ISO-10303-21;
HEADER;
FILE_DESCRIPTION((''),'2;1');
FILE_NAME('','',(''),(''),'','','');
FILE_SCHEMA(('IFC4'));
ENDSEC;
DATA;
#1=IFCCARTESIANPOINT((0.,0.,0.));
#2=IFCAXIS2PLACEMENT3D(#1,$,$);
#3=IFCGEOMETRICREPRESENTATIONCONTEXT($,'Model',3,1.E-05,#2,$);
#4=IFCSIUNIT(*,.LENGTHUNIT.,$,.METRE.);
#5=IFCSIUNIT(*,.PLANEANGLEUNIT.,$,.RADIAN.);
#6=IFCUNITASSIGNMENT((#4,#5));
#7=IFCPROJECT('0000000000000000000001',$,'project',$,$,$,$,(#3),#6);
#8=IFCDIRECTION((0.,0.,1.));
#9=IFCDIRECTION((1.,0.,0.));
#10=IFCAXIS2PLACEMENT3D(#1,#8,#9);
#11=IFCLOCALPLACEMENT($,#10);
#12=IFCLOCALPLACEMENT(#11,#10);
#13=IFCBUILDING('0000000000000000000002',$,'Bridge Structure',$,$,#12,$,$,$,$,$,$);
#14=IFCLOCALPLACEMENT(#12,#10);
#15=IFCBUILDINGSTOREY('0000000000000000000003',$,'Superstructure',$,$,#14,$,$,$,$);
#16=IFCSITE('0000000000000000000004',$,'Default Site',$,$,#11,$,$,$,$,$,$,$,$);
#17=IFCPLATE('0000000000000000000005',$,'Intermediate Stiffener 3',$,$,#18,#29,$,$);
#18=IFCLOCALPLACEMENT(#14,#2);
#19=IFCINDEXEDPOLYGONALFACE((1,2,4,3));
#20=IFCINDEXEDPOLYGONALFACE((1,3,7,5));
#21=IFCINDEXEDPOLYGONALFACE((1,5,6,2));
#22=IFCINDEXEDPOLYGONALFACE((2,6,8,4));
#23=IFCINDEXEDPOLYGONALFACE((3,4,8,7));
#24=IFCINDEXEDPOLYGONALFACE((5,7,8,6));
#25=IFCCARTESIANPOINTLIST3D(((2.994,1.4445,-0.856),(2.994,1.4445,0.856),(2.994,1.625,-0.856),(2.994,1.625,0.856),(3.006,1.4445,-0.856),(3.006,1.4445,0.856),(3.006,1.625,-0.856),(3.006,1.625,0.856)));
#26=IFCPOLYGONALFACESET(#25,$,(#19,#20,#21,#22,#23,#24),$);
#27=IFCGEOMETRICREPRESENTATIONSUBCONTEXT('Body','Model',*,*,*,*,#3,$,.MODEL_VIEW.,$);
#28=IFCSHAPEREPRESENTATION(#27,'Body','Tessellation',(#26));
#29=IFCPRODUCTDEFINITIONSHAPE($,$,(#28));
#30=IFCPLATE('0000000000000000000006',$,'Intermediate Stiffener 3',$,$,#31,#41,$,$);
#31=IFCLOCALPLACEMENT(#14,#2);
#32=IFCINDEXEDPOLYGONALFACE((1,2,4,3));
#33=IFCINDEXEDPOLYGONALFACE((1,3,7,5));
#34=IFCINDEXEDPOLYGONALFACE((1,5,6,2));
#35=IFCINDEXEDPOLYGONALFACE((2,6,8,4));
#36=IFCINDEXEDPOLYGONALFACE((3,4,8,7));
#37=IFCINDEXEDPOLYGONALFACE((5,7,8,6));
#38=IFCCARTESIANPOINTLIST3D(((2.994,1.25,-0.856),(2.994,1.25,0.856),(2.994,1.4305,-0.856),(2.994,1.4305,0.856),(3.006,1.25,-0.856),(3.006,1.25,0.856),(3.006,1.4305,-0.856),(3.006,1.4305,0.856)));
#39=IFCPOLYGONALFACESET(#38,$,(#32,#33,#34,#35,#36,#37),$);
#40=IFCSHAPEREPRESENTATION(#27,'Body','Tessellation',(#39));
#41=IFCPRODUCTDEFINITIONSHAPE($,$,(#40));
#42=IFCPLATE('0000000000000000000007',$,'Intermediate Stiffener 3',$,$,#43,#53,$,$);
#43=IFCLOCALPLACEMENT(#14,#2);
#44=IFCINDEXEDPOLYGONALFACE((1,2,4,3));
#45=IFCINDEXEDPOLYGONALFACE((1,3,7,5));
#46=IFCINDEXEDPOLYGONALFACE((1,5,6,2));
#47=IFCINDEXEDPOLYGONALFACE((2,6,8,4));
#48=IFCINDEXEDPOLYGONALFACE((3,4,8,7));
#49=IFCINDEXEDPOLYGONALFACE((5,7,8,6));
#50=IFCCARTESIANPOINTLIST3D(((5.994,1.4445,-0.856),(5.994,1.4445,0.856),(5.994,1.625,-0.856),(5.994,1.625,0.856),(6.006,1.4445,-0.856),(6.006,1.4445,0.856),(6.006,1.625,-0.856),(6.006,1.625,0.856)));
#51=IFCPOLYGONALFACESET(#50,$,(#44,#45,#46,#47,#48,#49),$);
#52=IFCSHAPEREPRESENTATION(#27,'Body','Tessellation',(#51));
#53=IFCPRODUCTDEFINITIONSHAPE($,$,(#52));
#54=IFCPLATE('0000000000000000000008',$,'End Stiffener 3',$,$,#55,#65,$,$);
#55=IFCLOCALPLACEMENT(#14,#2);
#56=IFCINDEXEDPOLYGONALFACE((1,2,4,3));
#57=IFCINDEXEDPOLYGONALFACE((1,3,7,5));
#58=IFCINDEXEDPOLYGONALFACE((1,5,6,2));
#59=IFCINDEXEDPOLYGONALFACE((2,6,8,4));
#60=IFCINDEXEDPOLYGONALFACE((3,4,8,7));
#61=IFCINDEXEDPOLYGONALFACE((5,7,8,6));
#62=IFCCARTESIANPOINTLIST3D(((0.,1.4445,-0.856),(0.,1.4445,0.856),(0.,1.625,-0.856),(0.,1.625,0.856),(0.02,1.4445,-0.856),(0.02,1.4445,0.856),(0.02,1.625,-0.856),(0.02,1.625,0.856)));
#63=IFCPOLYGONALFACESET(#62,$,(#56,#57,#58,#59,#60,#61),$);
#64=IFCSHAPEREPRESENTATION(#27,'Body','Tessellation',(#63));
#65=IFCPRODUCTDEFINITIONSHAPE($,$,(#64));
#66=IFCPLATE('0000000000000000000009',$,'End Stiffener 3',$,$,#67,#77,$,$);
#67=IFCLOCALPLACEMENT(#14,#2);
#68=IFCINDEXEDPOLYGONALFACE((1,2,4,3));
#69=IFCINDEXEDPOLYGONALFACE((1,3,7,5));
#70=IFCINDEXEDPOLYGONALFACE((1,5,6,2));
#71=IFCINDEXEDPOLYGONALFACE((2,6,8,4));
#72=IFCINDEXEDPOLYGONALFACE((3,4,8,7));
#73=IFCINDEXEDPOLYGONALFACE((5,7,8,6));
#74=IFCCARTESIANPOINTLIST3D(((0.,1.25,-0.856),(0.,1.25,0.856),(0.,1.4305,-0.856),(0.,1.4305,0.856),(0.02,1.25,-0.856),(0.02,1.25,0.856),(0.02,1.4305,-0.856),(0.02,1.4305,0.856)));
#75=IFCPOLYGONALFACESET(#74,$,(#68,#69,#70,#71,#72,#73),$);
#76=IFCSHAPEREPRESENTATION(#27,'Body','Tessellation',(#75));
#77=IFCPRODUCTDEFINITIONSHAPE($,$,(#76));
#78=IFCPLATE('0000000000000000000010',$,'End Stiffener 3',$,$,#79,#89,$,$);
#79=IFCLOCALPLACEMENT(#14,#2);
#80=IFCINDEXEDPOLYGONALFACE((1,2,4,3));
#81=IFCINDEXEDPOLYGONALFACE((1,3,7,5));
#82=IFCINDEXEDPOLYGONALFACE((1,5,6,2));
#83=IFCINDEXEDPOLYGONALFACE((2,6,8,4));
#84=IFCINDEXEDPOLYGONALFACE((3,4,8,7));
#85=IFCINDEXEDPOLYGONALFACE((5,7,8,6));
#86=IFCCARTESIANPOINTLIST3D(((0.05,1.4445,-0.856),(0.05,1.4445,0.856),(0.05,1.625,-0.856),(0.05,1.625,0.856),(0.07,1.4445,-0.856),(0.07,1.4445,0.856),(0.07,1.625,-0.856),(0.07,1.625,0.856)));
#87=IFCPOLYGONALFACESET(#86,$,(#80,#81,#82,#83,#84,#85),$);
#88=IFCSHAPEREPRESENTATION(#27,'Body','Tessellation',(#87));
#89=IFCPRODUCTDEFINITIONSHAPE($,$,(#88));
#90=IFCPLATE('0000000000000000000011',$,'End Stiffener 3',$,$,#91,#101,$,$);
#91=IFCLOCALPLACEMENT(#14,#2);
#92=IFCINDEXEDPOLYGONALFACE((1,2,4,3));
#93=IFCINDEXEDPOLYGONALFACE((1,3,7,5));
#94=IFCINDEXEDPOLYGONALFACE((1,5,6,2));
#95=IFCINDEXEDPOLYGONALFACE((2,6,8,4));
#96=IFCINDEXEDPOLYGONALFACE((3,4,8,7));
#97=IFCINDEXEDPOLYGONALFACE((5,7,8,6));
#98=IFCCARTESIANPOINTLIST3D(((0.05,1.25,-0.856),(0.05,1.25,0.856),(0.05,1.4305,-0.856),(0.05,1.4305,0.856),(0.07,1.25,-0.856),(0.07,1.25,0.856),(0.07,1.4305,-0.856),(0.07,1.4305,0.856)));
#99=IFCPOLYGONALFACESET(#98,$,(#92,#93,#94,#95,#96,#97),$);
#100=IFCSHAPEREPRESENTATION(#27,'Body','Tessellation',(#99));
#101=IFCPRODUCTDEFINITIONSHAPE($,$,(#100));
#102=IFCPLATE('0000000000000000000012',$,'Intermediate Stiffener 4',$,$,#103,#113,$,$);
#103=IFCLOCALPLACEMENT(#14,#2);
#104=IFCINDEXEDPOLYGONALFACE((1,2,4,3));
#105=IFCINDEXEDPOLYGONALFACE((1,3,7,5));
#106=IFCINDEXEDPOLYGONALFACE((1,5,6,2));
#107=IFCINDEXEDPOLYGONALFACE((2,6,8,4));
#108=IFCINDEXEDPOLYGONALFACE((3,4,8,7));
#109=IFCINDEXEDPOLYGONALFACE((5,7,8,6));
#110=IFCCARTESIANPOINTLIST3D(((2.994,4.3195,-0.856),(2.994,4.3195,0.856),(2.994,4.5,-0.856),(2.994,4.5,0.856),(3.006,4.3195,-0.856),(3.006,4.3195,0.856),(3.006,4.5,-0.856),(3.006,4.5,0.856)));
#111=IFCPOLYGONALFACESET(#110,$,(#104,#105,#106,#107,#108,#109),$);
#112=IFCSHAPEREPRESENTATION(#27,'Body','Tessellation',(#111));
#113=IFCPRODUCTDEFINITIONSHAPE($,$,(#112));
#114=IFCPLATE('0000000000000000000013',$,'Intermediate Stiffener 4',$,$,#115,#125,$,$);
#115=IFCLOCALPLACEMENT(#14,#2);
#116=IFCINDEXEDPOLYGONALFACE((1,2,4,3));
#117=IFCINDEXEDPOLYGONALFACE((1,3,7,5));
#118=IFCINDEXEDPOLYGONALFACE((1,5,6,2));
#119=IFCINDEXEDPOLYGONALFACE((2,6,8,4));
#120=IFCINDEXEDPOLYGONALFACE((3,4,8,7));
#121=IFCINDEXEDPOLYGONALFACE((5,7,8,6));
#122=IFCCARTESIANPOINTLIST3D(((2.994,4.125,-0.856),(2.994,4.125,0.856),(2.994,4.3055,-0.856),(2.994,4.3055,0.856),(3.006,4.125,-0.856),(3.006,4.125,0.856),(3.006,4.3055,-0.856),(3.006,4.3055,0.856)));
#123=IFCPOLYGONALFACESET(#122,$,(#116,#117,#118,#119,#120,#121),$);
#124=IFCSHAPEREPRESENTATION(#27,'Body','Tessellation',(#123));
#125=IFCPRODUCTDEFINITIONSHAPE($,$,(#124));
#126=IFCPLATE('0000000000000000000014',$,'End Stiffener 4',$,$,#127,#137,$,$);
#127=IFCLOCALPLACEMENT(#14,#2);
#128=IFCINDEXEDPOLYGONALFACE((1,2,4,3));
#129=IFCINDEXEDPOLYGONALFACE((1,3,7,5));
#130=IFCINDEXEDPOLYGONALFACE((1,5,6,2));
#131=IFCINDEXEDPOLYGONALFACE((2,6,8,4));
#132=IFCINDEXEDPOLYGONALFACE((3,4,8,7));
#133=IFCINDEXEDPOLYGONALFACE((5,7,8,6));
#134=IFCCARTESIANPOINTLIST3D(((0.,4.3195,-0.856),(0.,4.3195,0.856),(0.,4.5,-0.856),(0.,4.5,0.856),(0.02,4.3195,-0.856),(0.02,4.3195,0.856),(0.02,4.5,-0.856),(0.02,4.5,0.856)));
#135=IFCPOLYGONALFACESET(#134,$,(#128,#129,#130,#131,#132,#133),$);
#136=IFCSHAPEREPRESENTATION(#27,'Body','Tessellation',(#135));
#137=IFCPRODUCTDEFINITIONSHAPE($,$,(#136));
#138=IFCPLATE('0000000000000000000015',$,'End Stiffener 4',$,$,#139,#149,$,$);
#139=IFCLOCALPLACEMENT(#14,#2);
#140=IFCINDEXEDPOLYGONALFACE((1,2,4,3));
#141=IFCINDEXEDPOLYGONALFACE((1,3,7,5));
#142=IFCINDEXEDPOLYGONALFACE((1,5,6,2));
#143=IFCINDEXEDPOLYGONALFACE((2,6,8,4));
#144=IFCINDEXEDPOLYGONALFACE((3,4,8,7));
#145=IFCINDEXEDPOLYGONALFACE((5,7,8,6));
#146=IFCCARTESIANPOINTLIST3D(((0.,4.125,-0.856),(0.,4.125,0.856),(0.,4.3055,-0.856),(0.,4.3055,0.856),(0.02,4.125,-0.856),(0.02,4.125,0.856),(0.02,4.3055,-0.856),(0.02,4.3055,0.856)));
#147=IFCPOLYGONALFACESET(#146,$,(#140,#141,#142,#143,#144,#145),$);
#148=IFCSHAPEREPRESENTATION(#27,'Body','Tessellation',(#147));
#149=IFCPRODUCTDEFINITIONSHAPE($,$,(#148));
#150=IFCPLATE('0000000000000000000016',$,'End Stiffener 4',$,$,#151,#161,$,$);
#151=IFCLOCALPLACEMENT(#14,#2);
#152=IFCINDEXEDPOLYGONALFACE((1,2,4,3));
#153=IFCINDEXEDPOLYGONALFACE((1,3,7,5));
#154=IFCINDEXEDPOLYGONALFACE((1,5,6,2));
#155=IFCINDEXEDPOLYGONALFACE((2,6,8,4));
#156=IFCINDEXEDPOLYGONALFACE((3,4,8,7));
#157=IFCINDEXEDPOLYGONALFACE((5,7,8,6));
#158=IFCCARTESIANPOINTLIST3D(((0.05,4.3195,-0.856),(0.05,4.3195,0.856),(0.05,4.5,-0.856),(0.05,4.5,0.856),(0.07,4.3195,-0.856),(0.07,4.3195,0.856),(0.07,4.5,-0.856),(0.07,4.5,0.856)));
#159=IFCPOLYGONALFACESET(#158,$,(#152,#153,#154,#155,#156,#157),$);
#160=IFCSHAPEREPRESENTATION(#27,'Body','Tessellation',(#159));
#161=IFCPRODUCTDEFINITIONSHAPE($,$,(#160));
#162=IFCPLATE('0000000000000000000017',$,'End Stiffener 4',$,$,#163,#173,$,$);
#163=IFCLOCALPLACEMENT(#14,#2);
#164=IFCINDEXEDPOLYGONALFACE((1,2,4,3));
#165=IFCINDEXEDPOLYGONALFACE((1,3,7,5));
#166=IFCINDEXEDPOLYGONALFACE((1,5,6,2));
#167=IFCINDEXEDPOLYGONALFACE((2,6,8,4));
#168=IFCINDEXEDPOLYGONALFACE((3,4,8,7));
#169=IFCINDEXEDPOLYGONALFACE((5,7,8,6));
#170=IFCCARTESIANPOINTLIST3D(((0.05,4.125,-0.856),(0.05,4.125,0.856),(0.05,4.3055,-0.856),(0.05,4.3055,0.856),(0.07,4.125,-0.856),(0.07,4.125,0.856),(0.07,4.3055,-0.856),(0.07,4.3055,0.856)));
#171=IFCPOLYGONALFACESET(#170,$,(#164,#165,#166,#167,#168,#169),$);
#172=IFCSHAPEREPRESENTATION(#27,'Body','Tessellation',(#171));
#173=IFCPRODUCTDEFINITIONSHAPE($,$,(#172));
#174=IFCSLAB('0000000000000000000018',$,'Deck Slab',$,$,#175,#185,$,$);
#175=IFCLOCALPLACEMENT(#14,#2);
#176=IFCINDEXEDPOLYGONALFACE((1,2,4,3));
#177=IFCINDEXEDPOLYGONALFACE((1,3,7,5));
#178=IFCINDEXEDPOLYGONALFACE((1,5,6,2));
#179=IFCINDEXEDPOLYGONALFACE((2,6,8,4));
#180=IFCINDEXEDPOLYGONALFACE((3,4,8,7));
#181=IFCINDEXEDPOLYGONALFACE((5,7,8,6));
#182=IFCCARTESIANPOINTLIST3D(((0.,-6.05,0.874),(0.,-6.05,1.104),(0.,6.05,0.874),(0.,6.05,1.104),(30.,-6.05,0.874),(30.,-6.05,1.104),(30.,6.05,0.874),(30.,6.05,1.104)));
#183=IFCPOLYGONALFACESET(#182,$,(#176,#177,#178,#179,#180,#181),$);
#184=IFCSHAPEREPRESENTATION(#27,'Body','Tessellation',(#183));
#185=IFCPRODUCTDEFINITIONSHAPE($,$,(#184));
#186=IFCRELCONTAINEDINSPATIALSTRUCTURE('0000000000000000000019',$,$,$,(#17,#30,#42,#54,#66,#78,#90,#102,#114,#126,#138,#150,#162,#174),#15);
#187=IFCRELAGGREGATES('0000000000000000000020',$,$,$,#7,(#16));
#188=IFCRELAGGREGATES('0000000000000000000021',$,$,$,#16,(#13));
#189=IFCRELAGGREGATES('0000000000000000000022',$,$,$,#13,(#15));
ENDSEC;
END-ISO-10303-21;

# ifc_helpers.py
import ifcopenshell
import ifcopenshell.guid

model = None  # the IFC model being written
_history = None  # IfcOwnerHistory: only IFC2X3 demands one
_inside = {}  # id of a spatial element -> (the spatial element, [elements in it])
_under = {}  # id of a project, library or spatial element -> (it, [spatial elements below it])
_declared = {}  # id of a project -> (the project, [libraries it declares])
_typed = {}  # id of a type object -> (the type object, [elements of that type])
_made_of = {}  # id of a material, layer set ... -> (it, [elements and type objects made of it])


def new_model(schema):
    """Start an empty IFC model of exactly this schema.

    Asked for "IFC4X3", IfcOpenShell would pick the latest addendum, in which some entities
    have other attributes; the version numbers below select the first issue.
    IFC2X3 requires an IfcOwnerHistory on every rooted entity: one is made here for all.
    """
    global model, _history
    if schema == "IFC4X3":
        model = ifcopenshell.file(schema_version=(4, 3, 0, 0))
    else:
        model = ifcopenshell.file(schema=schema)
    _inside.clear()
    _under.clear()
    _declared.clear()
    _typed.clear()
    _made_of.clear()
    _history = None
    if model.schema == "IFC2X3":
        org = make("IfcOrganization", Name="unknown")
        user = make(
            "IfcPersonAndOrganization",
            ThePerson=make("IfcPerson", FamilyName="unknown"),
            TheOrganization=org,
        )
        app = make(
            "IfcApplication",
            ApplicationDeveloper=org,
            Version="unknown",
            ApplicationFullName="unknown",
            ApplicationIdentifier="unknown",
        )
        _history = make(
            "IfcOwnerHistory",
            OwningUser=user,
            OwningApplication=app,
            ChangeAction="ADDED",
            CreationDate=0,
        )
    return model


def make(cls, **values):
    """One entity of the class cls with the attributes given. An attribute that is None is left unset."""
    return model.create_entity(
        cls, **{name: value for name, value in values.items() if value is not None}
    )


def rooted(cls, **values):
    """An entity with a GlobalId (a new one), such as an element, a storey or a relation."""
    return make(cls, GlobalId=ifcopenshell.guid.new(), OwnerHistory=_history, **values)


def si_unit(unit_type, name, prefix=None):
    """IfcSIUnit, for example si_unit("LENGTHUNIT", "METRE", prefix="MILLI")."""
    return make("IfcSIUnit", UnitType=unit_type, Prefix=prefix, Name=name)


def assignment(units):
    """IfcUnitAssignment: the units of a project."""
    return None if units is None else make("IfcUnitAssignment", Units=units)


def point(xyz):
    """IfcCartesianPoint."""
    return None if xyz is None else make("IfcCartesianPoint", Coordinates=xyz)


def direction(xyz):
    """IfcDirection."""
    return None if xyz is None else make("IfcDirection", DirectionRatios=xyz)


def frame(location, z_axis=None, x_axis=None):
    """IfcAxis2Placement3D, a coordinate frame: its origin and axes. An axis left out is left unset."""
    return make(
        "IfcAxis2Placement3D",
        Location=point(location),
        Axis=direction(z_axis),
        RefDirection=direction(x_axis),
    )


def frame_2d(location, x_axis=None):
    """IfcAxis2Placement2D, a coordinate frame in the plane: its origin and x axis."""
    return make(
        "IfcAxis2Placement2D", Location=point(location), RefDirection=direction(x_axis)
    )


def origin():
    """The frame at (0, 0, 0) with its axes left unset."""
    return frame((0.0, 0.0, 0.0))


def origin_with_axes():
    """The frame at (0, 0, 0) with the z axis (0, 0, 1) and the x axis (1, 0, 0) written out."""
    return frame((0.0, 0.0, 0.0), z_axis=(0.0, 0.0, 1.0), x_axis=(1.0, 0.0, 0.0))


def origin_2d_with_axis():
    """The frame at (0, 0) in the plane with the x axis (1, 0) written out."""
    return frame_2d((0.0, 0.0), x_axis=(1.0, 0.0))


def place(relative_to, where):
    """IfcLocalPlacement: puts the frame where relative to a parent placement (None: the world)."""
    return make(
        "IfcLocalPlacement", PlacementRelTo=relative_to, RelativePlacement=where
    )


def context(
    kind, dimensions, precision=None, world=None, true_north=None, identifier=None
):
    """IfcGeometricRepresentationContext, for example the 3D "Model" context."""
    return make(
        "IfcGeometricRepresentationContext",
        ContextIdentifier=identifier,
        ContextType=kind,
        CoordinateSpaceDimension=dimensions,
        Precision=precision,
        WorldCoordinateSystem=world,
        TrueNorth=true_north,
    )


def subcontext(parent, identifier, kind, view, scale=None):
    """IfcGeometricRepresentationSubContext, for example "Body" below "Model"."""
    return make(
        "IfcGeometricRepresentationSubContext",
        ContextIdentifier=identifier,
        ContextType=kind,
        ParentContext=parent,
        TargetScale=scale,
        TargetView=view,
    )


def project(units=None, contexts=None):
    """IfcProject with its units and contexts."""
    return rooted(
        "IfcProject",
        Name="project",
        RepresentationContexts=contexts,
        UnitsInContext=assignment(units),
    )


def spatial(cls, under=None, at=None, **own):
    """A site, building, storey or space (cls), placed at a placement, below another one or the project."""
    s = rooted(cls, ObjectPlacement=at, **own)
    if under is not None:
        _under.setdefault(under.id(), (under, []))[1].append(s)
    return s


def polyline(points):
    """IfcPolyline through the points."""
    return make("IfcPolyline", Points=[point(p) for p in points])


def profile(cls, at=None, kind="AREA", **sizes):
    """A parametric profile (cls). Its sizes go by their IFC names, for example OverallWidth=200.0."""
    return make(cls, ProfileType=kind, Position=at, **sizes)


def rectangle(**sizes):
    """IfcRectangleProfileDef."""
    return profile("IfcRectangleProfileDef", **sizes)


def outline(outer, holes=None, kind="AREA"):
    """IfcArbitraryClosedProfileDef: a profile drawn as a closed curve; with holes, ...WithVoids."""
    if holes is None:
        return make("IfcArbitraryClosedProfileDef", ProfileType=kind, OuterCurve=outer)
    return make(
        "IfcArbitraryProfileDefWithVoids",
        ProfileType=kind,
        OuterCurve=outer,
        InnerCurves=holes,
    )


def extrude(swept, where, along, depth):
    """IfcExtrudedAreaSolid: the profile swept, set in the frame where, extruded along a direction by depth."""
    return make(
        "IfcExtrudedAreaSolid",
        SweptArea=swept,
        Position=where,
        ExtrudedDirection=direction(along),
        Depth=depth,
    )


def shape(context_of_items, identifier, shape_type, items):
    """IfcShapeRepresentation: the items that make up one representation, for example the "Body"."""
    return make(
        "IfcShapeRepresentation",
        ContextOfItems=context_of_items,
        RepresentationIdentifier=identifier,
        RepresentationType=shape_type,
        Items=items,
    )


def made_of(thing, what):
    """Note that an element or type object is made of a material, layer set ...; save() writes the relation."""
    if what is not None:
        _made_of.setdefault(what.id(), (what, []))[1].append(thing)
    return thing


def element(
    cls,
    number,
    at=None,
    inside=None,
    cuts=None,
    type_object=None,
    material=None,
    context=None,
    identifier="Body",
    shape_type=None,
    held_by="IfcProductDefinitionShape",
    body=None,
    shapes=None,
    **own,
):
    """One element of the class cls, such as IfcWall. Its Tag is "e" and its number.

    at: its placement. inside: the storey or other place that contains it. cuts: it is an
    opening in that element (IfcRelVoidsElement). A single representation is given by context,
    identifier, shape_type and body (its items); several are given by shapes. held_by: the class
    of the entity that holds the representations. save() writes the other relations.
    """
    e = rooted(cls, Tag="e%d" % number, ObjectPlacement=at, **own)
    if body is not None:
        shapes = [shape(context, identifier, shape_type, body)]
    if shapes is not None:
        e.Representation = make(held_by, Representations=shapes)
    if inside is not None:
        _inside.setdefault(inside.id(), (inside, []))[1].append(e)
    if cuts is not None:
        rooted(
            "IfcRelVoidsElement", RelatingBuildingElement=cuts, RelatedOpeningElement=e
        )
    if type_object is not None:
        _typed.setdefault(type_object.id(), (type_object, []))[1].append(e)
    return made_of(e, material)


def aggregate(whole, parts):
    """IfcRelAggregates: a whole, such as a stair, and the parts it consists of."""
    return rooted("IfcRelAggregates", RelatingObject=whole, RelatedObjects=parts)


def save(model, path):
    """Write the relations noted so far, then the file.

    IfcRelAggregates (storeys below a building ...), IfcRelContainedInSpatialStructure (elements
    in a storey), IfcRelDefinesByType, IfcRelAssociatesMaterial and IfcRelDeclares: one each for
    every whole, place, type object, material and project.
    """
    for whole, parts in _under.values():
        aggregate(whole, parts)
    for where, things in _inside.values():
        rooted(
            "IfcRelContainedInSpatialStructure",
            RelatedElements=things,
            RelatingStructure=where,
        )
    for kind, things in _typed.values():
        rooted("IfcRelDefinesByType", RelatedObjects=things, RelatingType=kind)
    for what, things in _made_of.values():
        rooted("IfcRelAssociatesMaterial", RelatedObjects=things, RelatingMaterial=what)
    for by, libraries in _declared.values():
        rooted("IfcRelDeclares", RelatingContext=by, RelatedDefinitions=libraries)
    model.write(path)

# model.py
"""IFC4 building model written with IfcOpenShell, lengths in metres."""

from ifc_helpers import new_model, si_unit, frame, origin, origin_with_axes, origin_2d_with_axis, place, context, subcontext, project, spatial, polyline, rectangle, outline, extrude, element, save


model = new_model("IFC4")

# Units and contexts
model_context = context("Model", 3, precision=1e-05, world=origin())
body_context = subcontext(model_context, "Body", "Model", "MODEL_VIEW")
ifc_project = project(units=[si_unit("LENGTHUNIT", "METRE"), si_unit("PLANEANGLEUNIT", "RADIAN")], contexts=[model_context])

# Site, building, storey
site_placement = place(None, origin_with_axes())
site = spatial("IfcSite", under=ifc_project, at=site_placement, Name="Default Site")
building_placement = place(site_placement, origin_with_axes())
building = spatial("IfcBuilding", under=site, at=building_placement, Name="Bridge Structure")
storey_placement = place(building_placement, origin_with_axes())
storey = spatial("IfcBuildingStorey", under=building, at=storey_placement, Name="Superstructure")

# Plates
for number, where, z_axis, x_axis, name in (
    (1, (3.0, 1.5348, -0.856), (0.0, 0.0, 1.0), (1.0, 0.0, 0.0), "Intermediate Stiffener 3"),
    (2, (3.0, 1.3402, -0.856), (0.0, 0.0, 1.0), (1.0, 0.0, 0.0), "Intermediate Stiffener 3"),
    (3, (6.0, 1.5348, -0.856), (0.0, 0.0, 1.0), (1.0, 0.0, 0.0), "Intermediate Stiffener 3"),
):
    element("IfcPlate", number, at=place(storey_placement, frame(where, z_axis=z_axis, x_axis=x_axis)), inside=storey, Name=name, context=body_context, shape_type="SweptSolid", body=[
        extrude(rectangle(XDim=0.012, YDim=0.1805, at=origin_2d_with_axis()), origin_with_axes(), (0.0, 0.0, 1.0), 1.712),
    ])
for number, where, z_axis, x_axis, name in (
    (4, (0.01, 1.5348, -0.856), (0.0, 0.0, 1.0), (1.0, 0.0, 0.0), "End Stiffener 3"),
    (5, (0.01, 1.3402, -0.856), (0.0, 0.0, 1.0), (1.0, 0.0, 0.0), "End Stiffener 3"),
    (6, (0.06, 1.5348, -0.856), (0.0, 0.0, 1.0), (1.0, 0.0, 0.0), "End Stiffener 3"),
    (7, (0.06, 1.3402, -0.856), (0.0, 0.0, 1.0), (1.0, 0.0, 0.0), "End Stiffener 3"),
):
    element("IfcPlate", number, at=place(storey_placement, frame(where, z_axis=z_axis, x_axis=x_axis)), inside=storey, Name=name, context=body_context, shape_type="SweptSolid", body=[
        extrude(rectangle(XDim=0.02, YDim=0.1805, at=origin_2d_with_axis()), origin_with_axes(), (0.0, 0.0, 1.0), 1.712),
    ])
for number, where, z_axis, x_axis, name in (
    (8, (3.0, 4.4097, -0.856), (0.0, 0.0, 1.0), (1.0, 0.0, 0.0), "Intermediate Stiffener 4"),
    (9, (3.0, 4.2153, -0.856), (0.0, 0.0, 1.0), (1.0, 0.0, 0.0), "Intermediate Stiffener 4"),
):
    element("IfcPlate", number, at=place(storey_placement, frame(where, z_axis=z_axis, x_axis=x_axis)), inside=storey, Name=name, context=body_context, shape_type="SweptSolid", body=[
        extrude(rectangle(XDim=0.012, YDim=0.1805, at=origin_2d_with_axis()), origin_with_axes(), (0.0, 0.0, 1.0), 1.712),
    ])
for number, where, z_axis, x_axis, name in (
    (10, (0.01, 4.4097, -0.856), (0.0, 0.0, 1.0), (1.0, 0.0, 0.0), "End Stiffener 4"),
    (11, (0.01, 4.2153, -0.856), (0.0, 0.0, 1.0), (1.0, 0.0, 0.0), "End Stiffener 4"),
    (12, (0.06, 4.4097, -0.856), (0.0, 0.0, 1.0), (1.0, 0.0, 0.0), "End Stiffener 4"),
    (13, (0.06, 4.2153, -0.856), (0.0, 0.0, 1.0), (1.0, 0.0, 0.0), "End Stiffener 4"),
):
    element("IfcPlate", number, at=place(storey_placement, frame(where, z_axis=z_axis, x_axis=x_axis)), inside=storey, Name=name, context=body_context, shape_type="SweptSolid", body=[
        extrude(rectangle(XDim=0.02, YDim=0.1805, at=origin_2d_with_axis()), origin_with_axes(), (0.0, 0.0, 1.0), 1.712),
    ])

# Slab
slab_placement = place(storey_placement, frame((0.0, 0.0, 0.874), z_axis=(0.0, 0.0, 1.0), x_axis=(1.0, 0.0, 0.0)))
element("IfcSlab", 14, at=slab_placement, inside=storey, Name="Deck Slab", context=body_context, shape_type="SweptSolid", body=[
    extrude(outline(polyline([(0.0, -6.05), (30.0, -6.05), (30.0, 6.05), (0.0, 6.05), (0.0, -6.05)])), origin_with_axes(), (0.0, 0.0, 1.0), 0.23),
])

save(model, "model.ifc")
